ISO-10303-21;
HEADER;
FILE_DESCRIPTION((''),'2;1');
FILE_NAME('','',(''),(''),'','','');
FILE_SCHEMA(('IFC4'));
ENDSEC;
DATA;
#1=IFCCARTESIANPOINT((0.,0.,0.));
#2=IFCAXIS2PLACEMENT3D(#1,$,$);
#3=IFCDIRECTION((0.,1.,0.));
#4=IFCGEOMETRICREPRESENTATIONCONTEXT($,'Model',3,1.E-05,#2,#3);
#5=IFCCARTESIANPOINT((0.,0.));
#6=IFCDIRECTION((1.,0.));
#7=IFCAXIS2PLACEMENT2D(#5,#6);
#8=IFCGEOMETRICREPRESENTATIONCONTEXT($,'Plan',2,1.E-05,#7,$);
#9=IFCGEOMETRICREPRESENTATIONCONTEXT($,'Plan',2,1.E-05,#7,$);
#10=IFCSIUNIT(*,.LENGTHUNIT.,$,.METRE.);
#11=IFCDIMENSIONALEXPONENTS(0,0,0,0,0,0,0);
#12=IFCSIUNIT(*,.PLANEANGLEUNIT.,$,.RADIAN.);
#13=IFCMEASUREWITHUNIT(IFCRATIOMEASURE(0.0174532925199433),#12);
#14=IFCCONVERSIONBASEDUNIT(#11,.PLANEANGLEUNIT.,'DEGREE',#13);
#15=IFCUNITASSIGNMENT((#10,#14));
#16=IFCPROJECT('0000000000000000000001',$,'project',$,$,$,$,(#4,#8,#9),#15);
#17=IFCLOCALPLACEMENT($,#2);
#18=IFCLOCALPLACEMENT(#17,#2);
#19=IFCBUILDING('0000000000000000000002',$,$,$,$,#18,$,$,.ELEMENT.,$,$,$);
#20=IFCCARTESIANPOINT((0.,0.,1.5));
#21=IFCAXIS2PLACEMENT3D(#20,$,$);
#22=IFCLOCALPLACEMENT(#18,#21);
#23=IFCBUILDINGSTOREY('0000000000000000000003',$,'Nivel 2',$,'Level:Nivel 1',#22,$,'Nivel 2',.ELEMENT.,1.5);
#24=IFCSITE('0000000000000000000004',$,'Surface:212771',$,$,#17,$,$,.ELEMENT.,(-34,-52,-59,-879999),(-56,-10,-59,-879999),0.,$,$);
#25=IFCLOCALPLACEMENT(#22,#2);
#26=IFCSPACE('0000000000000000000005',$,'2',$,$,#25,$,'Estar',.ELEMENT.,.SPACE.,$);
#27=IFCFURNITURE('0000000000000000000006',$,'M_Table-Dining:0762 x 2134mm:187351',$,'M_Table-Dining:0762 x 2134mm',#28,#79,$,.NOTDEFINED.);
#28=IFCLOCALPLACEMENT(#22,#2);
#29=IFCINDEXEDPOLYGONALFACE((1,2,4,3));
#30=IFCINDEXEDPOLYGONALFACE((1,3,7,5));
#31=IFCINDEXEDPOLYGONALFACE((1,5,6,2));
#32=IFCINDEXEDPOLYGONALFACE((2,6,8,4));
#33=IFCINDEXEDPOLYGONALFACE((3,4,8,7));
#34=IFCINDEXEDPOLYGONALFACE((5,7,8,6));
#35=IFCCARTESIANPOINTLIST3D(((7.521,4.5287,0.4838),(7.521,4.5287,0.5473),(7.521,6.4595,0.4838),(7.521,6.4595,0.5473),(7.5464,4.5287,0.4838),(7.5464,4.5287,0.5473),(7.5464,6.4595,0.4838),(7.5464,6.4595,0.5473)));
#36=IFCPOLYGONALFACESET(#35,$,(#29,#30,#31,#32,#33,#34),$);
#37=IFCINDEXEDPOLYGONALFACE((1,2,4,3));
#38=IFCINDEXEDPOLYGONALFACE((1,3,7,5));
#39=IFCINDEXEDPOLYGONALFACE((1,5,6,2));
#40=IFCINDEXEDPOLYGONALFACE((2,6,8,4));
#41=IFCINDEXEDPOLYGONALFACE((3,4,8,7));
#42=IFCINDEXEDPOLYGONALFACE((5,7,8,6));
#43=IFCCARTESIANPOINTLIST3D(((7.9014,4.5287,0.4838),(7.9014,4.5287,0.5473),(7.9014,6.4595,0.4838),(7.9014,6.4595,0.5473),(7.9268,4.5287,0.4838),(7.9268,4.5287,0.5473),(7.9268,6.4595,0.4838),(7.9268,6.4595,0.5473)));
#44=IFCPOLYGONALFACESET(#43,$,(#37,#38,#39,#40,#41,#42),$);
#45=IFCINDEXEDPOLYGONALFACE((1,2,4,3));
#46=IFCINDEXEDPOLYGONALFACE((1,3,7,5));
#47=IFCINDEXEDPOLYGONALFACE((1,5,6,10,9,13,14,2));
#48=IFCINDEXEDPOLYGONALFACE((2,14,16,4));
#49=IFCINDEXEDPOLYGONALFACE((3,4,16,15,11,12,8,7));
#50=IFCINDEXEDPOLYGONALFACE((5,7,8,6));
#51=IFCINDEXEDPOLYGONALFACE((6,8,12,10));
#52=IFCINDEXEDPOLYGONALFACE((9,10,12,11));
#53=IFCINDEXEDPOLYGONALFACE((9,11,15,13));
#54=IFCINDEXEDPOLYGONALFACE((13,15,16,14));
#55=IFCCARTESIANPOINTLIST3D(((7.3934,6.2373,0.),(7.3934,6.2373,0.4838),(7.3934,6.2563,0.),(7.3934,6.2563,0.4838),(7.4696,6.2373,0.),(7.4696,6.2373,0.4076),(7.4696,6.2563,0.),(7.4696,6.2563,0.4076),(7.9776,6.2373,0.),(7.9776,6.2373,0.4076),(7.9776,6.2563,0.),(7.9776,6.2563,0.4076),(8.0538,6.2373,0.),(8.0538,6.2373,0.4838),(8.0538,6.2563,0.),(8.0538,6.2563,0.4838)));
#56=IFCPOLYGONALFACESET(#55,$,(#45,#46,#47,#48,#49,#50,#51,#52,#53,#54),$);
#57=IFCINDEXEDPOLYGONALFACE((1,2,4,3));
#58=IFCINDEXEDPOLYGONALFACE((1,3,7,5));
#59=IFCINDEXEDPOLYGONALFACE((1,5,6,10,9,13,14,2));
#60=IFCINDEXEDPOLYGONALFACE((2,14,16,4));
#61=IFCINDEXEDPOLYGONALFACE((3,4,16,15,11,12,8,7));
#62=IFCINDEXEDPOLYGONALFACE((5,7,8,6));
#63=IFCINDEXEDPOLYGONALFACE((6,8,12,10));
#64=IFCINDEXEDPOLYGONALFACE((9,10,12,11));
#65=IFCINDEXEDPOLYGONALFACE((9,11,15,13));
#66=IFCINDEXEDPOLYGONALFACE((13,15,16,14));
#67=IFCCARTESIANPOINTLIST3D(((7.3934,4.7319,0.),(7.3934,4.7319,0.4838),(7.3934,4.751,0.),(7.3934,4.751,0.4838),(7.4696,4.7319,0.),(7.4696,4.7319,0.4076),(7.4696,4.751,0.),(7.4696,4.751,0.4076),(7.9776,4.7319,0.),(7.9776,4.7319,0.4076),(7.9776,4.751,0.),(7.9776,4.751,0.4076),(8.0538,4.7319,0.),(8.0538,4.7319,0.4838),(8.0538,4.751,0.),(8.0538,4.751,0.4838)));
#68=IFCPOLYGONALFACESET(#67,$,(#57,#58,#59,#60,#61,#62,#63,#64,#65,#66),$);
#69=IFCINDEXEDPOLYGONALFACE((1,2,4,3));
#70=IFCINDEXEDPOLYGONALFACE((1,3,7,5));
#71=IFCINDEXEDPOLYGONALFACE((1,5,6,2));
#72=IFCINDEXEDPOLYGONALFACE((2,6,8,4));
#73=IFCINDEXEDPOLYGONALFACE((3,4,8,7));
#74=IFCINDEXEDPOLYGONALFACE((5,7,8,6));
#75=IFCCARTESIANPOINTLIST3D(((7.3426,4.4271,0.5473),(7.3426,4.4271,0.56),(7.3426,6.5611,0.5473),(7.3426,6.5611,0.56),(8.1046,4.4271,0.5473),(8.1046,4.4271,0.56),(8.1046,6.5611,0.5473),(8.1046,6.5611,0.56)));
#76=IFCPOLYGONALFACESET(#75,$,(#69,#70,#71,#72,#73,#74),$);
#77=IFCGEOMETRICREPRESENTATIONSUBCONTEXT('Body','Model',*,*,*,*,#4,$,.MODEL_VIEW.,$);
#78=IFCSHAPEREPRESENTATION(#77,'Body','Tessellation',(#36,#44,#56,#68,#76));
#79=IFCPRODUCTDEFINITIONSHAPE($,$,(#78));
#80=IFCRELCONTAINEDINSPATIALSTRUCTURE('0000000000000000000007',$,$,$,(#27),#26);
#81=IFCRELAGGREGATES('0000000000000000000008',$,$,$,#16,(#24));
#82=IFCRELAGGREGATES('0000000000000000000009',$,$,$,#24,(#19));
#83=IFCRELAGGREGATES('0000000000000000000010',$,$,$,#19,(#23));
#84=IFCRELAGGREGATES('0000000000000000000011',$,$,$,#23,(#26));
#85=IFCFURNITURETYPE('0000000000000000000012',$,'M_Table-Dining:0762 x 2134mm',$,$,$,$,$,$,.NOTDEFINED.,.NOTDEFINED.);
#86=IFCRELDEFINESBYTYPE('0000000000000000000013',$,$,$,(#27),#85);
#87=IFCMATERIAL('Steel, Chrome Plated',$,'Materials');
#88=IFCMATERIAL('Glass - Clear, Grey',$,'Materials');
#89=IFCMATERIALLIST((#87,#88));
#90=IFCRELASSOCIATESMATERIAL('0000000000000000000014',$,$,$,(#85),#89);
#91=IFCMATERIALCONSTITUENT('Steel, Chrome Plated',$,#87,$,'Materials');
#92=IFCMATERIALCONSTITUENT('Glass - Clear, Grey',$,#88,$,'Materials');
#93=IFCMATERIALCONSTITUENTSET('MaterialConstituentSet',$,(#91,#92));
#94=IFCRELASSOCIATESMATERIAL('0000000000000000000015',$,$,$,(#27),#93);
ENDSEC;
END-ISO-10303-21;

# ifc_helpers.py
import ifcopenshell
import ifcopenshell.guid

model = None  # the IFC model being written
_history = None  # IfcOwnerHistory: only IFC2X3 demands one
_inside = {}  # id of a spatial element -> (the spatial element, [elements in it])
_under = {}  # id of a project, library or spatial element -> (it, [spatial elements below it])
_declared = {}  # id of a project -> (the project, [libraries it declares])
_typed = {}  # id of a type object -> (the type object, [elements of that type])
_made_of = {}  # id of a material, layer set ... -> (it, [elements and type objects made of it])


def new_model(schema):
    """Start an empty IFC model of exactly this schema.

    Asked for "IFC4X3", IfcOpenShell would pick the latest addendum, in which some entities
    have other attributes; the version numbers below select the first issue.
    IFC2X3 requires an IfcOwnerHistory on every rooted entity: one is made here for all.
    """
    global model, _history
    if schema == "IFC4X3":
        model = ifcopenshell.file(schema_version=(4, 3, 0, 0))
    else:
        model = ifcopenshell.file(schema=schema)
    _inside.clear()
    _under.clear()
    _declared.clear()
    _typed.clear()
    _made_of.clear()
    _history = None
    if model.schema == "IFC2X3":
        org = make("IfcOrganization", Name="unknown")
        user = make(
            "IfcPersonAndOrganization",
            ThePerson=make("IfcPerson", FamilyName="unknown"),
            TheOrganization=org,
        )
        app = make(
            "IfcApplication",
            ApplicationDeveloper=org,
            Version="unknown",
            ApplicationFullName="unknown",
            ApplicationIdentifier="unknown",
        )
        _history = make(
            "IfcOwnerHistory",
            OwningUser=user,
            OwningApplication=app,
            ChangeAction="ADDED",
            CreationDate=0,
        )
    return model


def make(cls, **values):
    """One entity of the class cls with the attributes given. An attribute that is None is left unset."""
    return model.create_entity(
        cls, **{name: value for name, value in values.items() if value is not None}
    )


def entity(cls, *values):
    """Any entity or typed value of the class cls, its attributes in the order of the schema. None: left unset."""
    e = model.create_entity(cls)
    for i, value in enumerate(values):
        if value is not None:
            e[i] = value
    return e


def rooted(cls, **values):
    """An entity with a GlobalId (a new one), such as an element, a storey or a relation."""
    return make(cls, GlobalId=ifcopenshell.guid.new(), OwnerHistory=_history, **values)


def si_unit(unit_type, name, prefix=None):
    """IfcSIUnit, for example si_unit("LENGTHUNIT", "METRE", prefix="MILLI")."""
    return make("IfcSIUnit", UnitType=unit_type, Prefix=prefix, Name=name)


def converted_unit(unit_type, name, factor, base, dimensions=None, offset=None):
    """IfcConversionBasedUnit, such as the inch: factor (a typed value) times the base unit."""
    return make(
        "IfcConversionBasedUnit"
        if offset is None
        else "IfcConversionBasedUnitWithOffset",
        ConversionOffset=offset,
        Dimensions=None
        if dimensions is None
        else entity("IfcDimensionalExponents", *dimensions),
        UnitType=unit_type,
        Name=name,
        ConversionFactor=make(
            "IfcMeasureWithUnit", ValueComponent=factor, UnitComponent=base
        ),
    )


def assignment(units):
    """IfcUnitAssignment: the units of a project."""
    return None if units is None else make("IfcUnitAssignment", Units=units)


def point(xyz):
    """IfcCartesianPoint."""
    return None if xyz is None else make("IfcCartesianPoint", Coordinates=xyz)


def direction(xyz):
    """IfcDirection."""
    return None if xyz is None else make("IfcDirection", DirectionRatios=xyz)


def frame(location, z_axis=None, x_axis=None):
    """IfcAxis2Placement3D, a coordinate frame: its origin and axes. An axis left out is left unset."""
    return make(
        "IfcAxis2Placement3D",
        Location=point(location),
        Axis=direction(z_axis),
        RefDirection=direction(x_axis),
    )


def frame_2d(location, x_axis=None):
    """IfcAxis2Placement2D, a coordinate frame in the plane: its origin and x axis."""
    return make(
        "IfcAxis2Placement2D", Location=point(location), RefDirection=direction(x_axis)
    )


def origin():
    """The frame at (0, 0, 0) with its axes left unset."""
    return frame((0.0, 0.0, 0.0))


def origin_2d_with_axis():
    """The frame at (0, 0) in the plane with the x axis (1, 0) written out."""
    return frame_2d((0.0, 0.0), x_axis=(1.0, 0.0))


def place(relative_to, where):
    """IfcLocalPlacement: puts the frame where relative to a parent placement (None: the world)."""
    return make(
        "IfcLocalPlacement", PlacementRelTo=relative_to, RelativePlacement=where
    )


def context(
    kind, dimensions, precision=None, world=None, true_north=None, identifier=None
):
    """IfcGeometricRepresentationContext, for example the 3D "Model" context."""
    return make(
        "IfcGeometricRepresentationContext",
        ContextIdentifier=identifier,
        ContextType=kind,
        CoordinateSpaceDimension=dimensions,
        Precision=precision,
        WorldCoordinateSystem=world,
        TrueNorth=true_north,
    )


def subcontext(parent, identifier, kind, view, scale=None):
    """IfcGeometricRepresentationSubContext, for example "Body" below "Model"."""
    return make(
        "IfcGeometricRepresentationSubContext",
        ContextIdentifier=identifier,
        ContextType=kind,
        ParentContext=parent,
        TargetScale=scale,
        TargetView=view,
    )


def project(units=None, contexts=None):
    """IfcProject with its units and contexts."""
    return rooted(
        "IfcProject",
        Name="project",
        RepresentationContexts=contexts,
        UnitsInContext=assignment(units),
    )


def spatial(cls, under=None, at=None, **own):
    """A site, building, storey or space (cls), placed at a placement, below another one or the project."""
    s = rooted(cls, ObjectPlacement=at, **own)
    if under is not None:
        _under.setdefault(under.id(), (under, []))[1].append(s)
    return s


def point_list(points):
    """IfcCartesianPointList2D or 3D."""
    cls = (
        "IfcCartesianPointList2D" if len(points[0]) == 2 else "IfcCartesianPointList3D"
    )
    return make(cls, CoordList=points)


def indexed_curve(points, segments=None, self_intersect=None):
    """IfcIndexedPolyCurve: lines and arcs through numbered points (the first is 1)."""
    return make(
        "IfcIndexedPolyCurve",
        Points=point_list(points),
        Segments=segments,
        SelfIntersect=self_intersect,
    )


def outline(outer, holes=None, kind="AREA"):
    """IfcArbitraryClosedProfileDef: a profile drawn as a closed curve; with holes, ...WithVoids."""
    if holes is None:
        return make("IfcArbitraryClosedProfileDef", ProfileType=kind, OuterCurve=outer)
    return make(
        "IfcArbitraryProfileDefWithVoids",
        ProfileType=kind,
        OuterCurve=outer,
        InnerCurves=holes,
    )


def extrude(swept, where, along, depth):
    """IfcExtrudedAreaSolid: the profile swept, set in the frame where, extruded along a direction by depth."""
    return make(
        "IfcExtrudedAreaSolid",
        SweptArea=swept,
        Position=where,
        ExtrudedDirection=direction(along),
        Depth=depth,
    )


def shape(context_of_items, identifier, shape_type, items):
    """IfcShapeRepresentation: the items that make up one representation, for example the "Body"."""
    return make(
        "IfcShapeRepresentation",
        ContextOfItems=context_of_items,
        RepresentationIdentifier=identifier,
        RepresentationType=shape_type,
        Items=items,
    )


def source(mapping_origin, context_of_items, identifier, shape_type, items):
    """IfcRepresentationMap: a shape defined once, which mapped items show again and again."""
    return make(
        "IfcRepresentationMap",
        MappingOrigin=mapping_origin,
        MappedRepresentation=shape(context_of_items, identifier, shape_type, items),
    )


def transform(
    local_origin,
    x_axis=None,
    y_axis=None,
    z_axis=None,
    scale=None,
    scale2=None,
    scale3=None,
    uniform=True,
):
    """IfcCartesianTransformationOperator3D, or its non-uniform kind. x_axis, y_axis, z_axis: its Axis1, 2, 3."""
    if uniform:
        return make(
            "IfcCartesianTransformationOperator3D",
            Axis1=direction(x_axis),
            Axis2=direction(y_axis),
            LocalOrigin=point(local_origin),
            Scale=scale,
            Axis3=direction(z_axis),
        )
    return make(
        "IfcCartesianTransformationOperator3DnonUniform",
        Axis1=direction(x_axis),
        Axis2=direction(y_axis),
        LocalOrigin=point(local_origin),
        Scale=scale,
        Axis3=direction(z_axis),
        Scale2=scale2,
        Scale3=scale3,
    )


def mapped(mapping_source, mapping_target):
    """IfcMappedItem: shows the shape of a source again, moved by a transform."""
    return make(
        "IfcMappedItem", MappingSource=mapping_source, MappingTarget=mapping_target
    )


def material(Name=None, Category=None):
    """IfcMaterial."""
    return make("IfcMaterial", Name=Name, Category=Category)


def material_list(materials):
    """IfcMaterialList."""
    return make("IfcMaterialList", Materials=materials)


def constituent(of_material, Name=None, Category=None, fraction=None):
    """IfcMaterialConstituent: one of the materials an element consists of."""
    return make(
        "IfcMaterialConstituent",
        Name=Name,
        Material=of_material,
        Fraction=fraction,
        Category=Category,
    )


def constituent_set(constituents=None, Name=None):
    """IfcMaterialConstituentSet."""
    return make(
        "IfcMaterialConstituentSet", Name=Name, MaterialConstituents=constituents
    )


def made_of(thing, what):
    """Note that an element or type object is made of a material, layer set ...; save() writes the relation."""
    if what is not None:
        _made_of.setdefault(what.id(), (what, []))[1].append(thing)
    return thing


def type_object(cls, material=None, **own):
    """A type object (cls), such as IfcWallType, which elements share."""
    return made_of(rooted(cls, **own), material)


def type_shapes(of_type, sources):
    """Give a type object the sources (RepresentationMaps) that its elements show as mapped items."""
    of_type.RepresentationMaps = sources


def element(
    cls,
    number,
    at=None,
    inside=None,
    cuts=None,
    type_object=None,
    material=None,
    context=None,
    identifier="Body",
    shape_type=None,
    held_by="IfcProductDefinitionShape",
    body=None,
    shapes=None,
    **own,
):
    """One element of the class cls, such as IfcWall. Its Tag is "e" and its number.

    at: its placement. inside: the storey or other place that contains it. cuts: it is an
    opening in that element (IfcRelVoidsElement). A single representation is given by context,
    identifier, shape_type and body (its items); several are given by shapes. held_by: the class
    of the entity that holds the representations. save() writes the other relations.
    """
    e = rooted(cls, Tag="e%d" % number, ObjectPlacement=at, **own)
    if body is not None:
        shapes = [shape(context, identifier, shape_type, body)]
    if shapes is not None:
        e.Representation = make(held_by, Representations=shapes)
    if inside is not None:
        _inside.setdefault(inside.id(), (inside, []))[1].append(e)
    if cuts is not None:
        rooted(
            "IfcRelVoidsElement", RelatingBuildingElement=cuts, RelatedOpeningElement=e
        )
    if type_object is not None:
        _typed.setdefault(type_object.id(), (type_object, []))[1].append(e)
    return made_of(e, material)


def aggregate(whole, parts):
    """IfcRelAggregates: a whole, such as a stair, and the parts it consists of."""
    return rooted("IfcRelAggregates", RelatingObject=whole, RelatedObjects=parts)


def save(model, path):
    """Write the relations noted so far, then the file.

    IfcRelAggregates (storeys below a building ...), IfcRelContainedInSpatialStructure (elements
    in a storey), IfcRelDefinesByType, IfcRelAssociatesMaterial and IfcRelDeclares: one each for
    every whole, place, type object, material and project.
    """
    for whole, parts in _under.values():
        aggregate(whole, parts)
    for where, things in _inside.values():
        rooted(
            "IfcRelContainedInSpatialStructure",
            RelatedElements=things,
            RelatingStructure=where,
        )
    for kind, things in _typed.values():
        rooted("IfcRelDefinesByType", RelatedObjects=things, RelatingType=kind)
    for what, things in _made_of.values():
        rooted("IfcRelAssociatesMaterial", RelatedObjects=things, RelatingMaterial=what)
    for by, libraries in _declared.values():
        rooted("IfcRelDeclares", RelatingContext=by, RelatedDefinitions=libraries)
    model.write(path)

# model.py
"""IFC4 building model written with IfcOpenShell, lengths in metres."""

from ifc_helpers import new_model, entity, si_unit, converted_unit, direction, frame, origin, origin_2d_with_axis, place, context, subcontext, project, spatial, indexed_curve, outline, extrude, source, transform, mapped, material, material_list, constituent, constituent_set, type_object, type_shapes, element, save


model = new_model("IFC4")

# Units and contexts
model_context = context("Model", 3, precision=1e-05, world=origin(), true_north=direction((0.0, 1.0, 0.0)))
plan_context_1 = context("Plan", 2, precision=1e-05, world=origin_2d_with_axis())
plan_context_2 = context("Plan", 2, precision=1e-05, world=origin_2d_with_axis())
body_context = subcontext(model_context, "Body", "Model", "MODEL_VIEW")
ifc_project = project(units=[si_unit("LENGTHUNIT", "METRE"), converted_unit("PLANEANGLEUNIT", "DEGREE", entity("IfcRatioMeasure", 0.0174532925199433), si_unit("PLANEANGLEUNIT", "RADIAN"), dimensions=[0, 0, 0, 0, 0, 0, 0])], contexts=[model_context, plan_context_1, plan_context_2])

# Site, building, storey
site_placement = place(None, origin())
site = spatial("IfcSite", under=ifc_project, at=site_placement, Name="Surface:212771", CompositionType="ELEMENT", RefLatitude=(-34, -52, -59, -879999), RefLongitude=(-56, -10, -59, -879999), RefElevation=0.0)
building_placement = place(site_placement, origin())
building = spatial("IfcBuilding", under=site, at=building_placement, CompositionType="ELEMENT")
storey_placement = place(building_placement, frame((0.0, 0.0, 1.5)))
storey = spatial("IfcBuildingStorey", under=building, at=storey_placement, Name="Nivel 2", ObjectType="Level:Nivel 1", LongName="Nivel 2", CompositionType="ELEMENT", Elevation=1.5)

# Shared definitions
space_placement = place(storey_placement, origin())
space = spatial("IfcSpace", under=storey, at=space_placement, Name="2", LongName="Estar", CompositionType="ELEMENT", PredefinedType="SPACE")

# Furniture
ifc_material_1 = material(Name="Steel, Chrome Plated", Category="Materials")
ifc_constituent_1 = constituent(ifc_material_1, Name="Steel, Chrome Plated", Category="Materials")
ifc_material_2 = material(Name="Glass - Clear, Grey", Category="Materials")
ifc_constituent_2 = constituent(ifc_material_2, Name="Glass - Clear, Grey", Category="Materials")
ifc_constituent_set = constituent_set(constituents=[ifc_constituent_1, ifc_constituent_2], Name="MaterialConstituentSet")
ifc_material_list = material_list([ifc_material_1, ifc_material_2])
furniture_type = type_object("IfcFurnitureType", Name="M_Table-Dining:0762 x 2134mm", AssemblyPlace="NOTDEFINED", PredefinedType="NOTDEFINED", material=ifc_material_list)
shared_shape_1 = source(origin(), body_context, "Body", "SweptSolid", [
    extrude(outline(indexed_curve([(-0.9654, -0.0127), (0.9654, -0.0127), (0.9654, 0.0127), (-0.9654, 0.0127), (-0.9654, -0.0127)], self_intersect=False)), frame((0.0183, 0.2851, 0.4838), z_axis=(0.0, 0.0, 1.0), x_axis=(-1.0, 0.0, 0.0)), (0.0, 0.0, 1.0), 0.0635),
    extrude(outline(indexed_curve([(-0.9654, -0.0127), (0.9654, -0.0127), (0.9654, 0.0127), (-0.9654, 0.0127), (-0.9654, -0.0127)], self_intersect=False)), frame((0.0183, -0.0953, 0.4838), z_axis=(0.0, 0.0, 1.0), x_axis=(-1.0, 0.0, 0.0)), (0.0, 0.0, 1.0), 0.0635),
    extrude(outline(indexed_curve([(-0.2228, -0.3302), (0.2609, -0.3302), (0.2609, 0.3302), (-0.2228, 0.3302), (-0.2228, 0.254), (0.1847, 0.254), (0.1847, -0.254), (-0.2228, -0.254), (-0.2228, -0.3302)], self_intersect=False)), frame((0.7614, 0.0952, 0.2228), z_axis=(1.0, 0.0, 0.0), x_axis=(0.0, 0.0, 1.0)), (0.0, 0.0, 1.0), 0.0191),
    extrude(outline(indexed_curve([(-0.3302, -0.261), (0.3302, -0.261), (0.3302, 0.2228), (0.254, 0.2228), (0.254, -0.1847), (-0.254, -0.1847), (-0.254, 0.2228), (-0.3302, 0.2228), (-0.3302, -0.261)], self_intersect=False)), frame((-0.7439, 0.0952, 0.2228), z_axis=(1.0, 0.0, 0.0), x_axis=(0.0, -1.0, 0.0)), (0.0, 0.0, 1.0), 0.0191),
    extrude(outline(indexed_curve([(-1.067, -0.381), (1.067, -0.381), (1.067, 0.381), (-1.067, 0.381), (-1.067, -0.381)], self_intersect=False)), frame((0.0183, 0.0952, 0.5473), z_axis=(0.0, 0.0, 1.0), x_axis=(-1.0, 0.0, 0.0)), (0.0, 0.0, 1.0), 0.0127),
])
type_shapes(furniture_type, [shared_shape_1])
furniture_placement = place(space_placement, frame((7.8188, 5.4759, 0.0), z_axis=(0.0, 0.0, 1.0), x_axis=(0.0, 1.0, 0.0)))
element("IfcFurniture", 1, at=furniture_placement, inside=space, type_object=furniture_type, material=ifc_constituent_set, Name="M_Table-Dining:0762 x 2134mm:187351", ObjectType="M_Table-Dining:0762 x 2134mm", PredefinedType="NOTDEFINED", context=body_context, shape_type="MappedRepresentation", body=[
    mapped(shared_shape_1, transform((0.0, 0.0, 0.0), scale=1.0)),
])

save(model, "model.ifc")
